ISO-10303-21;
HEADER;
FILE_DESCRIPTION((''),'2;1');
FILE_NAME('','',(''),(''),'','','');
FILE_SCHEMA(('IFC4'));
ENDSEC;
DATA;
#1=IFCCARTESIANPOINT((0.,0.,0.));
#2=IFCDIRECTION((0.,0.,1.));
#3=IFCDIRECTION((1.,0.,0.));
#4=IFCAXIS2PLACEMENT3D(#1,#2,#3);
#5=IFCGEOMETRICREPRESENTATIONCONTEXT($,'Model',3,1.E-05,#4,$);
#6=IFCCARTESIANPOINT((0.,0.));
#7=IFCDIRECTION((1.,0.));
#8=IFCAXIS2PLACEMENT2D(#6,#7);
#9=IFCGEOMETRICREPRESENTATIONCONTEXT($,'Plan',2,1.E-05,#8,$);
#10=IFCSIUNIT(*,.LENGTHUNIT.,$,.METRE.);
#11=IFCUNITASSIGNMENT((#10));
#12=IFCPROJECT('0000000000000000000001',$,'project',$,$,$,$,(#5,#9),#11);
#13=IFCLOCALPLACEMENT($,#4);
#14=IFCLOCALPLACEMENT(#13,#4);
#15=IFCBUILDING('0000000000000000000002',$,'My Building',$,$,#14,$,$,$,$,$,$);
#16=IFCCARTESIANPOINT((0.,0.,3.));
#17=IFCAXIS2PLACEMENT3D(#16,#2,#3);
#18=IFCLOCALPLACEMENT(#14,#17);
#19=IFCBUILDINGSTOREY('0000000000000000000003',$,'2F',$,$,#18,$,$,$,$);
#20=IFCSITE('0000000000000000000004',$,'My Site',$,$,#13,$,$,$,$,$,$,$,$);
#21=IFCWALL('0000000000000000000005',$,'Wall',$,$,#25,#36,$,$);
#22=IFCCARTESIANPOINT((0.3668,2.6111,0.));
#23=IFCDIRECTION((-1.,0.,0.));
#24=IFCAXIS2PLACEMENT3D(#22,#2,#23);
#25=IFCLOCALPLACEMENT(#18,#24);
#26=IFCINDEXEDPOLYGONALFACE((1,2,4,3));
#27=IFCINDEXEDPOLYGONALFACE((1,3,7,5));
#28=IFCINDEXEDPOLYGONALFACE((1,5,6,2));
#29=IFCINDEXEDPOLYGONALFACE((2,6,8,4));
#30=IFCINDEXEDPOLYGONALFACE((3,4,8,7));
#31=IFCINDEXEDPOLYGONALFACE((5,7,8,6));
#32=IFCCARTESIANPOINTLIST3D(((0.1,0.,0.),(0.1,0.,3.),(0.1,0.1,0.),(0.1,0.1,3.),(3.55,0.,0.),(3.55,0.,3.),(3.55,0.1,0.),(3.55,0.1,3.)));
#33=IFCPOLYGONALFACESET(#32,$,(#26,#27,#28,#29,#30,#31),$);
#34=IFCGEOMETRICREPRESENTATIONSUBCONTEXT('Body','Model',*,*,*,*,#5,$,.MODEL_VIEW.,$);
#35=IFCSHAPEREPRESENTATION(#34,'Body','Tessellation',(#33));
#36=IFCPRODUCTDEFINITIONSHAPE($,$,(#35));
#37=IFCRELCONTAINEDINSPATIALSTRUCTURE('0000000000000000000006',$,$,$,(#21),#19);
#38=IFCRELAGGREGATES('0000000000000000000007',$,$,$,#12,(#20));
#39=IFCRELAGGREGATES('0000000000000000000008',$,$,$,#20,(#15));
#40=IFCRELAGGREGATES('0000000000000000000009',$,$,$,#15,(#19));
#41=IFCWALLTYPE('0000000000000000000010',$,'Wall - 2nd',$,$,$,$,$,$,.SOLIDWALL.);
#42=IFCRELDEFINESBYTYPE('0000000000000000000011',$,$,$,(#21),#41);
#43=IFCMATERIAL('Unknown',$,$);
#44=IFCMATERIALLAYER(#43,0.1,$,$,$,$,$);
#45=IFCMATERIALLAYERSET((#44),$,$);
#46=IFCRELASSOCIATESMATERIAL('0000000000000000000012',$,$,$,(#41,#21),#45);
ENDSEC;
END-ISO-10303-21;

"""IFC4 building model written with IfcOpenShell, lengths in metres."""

from ifc_helpers import new_model, si_unit, frame, origin_with_axes, origin_2d_with_axis, place, context, subcontext, project, spatial, line, indexed_curve, outline, extrude, material, layer, layer_set, layer_usage, type_object, element, save


model = new_model("IFC4")

# Units and contexts
model_context = context("Model", 3, precision=1e-05, world=origin_with_axes())
plan_context = context("Plan", 2, precision=1e-05, world=origin_2d_with_axis())
body_context_1 = subcontext(model_context, "Body", "Model", "MODEL_VIEW")
ifc_project = project(units=[si_unit("LENGTHUNIT", "METRE")], contexts=[model_context, plan_context])

# Site, building, storey
site_placement = place(None, origin_with_axes())
site = spatial("IfcSite", under=ifc_project, at=site_placement, Name="My Site")
building_placement = place(site_placement, origin_with_axes())
building = spatial("IfcBuilding", under=site, at=building_placement, Name="My Building")
storey_placement = place(building_placement, frame((0.0, 0.0, 3.0), z_axis=(0.0, 0.0, 1.0), x_axis=(1.0, 0.0, 0.0)))
storey = spatial("IfcBuildingStorey", under=building, at=storey_placement, Name="2F")

# Shared definitions
ifc_material = material(Name="Unknown")

# Shared definitions
ifc_layer_1 = layer(ifc_material, 0.1)
ifc_layer_set_1 = layer_set([ifc_layer_1])
wall_type = type_object("IfcWallType", Name="Wall - 2nd", PredefinedType="SOLIDWALL", material=ifc_layer_set_1)

# Wall
ifc_layer_usage_1 = layer_usage(ifc_layer_set_1, "AXIS2", "POSITIVE", 0.0)
wall_1_placement = place(storey_placement, frame((0.3668, 2.6111, 0.0), z_axis=(0.0, 0.0, 1.0), x_axis=(-1.0, 0.0, 0.0)))
element("IfcWall", 1, at=wall_1_placement, inside=storey, type_object=wall_type, material=ifc_layer_usage_1, Name="Wall", context=body_context_1, shape_type="SweptSolid", body=[
    extrude(outline(indexed_curve([(0.1, 0.0), (0.1, 0.1), (3.55, 0.1), (3.55, 0.0)], segments=[line(1, 2, 3, 4, 1)])), origin_with_axes(), (0.0, 0.0, 1.0), 3.0),
])

save(model, "model.ifc")
